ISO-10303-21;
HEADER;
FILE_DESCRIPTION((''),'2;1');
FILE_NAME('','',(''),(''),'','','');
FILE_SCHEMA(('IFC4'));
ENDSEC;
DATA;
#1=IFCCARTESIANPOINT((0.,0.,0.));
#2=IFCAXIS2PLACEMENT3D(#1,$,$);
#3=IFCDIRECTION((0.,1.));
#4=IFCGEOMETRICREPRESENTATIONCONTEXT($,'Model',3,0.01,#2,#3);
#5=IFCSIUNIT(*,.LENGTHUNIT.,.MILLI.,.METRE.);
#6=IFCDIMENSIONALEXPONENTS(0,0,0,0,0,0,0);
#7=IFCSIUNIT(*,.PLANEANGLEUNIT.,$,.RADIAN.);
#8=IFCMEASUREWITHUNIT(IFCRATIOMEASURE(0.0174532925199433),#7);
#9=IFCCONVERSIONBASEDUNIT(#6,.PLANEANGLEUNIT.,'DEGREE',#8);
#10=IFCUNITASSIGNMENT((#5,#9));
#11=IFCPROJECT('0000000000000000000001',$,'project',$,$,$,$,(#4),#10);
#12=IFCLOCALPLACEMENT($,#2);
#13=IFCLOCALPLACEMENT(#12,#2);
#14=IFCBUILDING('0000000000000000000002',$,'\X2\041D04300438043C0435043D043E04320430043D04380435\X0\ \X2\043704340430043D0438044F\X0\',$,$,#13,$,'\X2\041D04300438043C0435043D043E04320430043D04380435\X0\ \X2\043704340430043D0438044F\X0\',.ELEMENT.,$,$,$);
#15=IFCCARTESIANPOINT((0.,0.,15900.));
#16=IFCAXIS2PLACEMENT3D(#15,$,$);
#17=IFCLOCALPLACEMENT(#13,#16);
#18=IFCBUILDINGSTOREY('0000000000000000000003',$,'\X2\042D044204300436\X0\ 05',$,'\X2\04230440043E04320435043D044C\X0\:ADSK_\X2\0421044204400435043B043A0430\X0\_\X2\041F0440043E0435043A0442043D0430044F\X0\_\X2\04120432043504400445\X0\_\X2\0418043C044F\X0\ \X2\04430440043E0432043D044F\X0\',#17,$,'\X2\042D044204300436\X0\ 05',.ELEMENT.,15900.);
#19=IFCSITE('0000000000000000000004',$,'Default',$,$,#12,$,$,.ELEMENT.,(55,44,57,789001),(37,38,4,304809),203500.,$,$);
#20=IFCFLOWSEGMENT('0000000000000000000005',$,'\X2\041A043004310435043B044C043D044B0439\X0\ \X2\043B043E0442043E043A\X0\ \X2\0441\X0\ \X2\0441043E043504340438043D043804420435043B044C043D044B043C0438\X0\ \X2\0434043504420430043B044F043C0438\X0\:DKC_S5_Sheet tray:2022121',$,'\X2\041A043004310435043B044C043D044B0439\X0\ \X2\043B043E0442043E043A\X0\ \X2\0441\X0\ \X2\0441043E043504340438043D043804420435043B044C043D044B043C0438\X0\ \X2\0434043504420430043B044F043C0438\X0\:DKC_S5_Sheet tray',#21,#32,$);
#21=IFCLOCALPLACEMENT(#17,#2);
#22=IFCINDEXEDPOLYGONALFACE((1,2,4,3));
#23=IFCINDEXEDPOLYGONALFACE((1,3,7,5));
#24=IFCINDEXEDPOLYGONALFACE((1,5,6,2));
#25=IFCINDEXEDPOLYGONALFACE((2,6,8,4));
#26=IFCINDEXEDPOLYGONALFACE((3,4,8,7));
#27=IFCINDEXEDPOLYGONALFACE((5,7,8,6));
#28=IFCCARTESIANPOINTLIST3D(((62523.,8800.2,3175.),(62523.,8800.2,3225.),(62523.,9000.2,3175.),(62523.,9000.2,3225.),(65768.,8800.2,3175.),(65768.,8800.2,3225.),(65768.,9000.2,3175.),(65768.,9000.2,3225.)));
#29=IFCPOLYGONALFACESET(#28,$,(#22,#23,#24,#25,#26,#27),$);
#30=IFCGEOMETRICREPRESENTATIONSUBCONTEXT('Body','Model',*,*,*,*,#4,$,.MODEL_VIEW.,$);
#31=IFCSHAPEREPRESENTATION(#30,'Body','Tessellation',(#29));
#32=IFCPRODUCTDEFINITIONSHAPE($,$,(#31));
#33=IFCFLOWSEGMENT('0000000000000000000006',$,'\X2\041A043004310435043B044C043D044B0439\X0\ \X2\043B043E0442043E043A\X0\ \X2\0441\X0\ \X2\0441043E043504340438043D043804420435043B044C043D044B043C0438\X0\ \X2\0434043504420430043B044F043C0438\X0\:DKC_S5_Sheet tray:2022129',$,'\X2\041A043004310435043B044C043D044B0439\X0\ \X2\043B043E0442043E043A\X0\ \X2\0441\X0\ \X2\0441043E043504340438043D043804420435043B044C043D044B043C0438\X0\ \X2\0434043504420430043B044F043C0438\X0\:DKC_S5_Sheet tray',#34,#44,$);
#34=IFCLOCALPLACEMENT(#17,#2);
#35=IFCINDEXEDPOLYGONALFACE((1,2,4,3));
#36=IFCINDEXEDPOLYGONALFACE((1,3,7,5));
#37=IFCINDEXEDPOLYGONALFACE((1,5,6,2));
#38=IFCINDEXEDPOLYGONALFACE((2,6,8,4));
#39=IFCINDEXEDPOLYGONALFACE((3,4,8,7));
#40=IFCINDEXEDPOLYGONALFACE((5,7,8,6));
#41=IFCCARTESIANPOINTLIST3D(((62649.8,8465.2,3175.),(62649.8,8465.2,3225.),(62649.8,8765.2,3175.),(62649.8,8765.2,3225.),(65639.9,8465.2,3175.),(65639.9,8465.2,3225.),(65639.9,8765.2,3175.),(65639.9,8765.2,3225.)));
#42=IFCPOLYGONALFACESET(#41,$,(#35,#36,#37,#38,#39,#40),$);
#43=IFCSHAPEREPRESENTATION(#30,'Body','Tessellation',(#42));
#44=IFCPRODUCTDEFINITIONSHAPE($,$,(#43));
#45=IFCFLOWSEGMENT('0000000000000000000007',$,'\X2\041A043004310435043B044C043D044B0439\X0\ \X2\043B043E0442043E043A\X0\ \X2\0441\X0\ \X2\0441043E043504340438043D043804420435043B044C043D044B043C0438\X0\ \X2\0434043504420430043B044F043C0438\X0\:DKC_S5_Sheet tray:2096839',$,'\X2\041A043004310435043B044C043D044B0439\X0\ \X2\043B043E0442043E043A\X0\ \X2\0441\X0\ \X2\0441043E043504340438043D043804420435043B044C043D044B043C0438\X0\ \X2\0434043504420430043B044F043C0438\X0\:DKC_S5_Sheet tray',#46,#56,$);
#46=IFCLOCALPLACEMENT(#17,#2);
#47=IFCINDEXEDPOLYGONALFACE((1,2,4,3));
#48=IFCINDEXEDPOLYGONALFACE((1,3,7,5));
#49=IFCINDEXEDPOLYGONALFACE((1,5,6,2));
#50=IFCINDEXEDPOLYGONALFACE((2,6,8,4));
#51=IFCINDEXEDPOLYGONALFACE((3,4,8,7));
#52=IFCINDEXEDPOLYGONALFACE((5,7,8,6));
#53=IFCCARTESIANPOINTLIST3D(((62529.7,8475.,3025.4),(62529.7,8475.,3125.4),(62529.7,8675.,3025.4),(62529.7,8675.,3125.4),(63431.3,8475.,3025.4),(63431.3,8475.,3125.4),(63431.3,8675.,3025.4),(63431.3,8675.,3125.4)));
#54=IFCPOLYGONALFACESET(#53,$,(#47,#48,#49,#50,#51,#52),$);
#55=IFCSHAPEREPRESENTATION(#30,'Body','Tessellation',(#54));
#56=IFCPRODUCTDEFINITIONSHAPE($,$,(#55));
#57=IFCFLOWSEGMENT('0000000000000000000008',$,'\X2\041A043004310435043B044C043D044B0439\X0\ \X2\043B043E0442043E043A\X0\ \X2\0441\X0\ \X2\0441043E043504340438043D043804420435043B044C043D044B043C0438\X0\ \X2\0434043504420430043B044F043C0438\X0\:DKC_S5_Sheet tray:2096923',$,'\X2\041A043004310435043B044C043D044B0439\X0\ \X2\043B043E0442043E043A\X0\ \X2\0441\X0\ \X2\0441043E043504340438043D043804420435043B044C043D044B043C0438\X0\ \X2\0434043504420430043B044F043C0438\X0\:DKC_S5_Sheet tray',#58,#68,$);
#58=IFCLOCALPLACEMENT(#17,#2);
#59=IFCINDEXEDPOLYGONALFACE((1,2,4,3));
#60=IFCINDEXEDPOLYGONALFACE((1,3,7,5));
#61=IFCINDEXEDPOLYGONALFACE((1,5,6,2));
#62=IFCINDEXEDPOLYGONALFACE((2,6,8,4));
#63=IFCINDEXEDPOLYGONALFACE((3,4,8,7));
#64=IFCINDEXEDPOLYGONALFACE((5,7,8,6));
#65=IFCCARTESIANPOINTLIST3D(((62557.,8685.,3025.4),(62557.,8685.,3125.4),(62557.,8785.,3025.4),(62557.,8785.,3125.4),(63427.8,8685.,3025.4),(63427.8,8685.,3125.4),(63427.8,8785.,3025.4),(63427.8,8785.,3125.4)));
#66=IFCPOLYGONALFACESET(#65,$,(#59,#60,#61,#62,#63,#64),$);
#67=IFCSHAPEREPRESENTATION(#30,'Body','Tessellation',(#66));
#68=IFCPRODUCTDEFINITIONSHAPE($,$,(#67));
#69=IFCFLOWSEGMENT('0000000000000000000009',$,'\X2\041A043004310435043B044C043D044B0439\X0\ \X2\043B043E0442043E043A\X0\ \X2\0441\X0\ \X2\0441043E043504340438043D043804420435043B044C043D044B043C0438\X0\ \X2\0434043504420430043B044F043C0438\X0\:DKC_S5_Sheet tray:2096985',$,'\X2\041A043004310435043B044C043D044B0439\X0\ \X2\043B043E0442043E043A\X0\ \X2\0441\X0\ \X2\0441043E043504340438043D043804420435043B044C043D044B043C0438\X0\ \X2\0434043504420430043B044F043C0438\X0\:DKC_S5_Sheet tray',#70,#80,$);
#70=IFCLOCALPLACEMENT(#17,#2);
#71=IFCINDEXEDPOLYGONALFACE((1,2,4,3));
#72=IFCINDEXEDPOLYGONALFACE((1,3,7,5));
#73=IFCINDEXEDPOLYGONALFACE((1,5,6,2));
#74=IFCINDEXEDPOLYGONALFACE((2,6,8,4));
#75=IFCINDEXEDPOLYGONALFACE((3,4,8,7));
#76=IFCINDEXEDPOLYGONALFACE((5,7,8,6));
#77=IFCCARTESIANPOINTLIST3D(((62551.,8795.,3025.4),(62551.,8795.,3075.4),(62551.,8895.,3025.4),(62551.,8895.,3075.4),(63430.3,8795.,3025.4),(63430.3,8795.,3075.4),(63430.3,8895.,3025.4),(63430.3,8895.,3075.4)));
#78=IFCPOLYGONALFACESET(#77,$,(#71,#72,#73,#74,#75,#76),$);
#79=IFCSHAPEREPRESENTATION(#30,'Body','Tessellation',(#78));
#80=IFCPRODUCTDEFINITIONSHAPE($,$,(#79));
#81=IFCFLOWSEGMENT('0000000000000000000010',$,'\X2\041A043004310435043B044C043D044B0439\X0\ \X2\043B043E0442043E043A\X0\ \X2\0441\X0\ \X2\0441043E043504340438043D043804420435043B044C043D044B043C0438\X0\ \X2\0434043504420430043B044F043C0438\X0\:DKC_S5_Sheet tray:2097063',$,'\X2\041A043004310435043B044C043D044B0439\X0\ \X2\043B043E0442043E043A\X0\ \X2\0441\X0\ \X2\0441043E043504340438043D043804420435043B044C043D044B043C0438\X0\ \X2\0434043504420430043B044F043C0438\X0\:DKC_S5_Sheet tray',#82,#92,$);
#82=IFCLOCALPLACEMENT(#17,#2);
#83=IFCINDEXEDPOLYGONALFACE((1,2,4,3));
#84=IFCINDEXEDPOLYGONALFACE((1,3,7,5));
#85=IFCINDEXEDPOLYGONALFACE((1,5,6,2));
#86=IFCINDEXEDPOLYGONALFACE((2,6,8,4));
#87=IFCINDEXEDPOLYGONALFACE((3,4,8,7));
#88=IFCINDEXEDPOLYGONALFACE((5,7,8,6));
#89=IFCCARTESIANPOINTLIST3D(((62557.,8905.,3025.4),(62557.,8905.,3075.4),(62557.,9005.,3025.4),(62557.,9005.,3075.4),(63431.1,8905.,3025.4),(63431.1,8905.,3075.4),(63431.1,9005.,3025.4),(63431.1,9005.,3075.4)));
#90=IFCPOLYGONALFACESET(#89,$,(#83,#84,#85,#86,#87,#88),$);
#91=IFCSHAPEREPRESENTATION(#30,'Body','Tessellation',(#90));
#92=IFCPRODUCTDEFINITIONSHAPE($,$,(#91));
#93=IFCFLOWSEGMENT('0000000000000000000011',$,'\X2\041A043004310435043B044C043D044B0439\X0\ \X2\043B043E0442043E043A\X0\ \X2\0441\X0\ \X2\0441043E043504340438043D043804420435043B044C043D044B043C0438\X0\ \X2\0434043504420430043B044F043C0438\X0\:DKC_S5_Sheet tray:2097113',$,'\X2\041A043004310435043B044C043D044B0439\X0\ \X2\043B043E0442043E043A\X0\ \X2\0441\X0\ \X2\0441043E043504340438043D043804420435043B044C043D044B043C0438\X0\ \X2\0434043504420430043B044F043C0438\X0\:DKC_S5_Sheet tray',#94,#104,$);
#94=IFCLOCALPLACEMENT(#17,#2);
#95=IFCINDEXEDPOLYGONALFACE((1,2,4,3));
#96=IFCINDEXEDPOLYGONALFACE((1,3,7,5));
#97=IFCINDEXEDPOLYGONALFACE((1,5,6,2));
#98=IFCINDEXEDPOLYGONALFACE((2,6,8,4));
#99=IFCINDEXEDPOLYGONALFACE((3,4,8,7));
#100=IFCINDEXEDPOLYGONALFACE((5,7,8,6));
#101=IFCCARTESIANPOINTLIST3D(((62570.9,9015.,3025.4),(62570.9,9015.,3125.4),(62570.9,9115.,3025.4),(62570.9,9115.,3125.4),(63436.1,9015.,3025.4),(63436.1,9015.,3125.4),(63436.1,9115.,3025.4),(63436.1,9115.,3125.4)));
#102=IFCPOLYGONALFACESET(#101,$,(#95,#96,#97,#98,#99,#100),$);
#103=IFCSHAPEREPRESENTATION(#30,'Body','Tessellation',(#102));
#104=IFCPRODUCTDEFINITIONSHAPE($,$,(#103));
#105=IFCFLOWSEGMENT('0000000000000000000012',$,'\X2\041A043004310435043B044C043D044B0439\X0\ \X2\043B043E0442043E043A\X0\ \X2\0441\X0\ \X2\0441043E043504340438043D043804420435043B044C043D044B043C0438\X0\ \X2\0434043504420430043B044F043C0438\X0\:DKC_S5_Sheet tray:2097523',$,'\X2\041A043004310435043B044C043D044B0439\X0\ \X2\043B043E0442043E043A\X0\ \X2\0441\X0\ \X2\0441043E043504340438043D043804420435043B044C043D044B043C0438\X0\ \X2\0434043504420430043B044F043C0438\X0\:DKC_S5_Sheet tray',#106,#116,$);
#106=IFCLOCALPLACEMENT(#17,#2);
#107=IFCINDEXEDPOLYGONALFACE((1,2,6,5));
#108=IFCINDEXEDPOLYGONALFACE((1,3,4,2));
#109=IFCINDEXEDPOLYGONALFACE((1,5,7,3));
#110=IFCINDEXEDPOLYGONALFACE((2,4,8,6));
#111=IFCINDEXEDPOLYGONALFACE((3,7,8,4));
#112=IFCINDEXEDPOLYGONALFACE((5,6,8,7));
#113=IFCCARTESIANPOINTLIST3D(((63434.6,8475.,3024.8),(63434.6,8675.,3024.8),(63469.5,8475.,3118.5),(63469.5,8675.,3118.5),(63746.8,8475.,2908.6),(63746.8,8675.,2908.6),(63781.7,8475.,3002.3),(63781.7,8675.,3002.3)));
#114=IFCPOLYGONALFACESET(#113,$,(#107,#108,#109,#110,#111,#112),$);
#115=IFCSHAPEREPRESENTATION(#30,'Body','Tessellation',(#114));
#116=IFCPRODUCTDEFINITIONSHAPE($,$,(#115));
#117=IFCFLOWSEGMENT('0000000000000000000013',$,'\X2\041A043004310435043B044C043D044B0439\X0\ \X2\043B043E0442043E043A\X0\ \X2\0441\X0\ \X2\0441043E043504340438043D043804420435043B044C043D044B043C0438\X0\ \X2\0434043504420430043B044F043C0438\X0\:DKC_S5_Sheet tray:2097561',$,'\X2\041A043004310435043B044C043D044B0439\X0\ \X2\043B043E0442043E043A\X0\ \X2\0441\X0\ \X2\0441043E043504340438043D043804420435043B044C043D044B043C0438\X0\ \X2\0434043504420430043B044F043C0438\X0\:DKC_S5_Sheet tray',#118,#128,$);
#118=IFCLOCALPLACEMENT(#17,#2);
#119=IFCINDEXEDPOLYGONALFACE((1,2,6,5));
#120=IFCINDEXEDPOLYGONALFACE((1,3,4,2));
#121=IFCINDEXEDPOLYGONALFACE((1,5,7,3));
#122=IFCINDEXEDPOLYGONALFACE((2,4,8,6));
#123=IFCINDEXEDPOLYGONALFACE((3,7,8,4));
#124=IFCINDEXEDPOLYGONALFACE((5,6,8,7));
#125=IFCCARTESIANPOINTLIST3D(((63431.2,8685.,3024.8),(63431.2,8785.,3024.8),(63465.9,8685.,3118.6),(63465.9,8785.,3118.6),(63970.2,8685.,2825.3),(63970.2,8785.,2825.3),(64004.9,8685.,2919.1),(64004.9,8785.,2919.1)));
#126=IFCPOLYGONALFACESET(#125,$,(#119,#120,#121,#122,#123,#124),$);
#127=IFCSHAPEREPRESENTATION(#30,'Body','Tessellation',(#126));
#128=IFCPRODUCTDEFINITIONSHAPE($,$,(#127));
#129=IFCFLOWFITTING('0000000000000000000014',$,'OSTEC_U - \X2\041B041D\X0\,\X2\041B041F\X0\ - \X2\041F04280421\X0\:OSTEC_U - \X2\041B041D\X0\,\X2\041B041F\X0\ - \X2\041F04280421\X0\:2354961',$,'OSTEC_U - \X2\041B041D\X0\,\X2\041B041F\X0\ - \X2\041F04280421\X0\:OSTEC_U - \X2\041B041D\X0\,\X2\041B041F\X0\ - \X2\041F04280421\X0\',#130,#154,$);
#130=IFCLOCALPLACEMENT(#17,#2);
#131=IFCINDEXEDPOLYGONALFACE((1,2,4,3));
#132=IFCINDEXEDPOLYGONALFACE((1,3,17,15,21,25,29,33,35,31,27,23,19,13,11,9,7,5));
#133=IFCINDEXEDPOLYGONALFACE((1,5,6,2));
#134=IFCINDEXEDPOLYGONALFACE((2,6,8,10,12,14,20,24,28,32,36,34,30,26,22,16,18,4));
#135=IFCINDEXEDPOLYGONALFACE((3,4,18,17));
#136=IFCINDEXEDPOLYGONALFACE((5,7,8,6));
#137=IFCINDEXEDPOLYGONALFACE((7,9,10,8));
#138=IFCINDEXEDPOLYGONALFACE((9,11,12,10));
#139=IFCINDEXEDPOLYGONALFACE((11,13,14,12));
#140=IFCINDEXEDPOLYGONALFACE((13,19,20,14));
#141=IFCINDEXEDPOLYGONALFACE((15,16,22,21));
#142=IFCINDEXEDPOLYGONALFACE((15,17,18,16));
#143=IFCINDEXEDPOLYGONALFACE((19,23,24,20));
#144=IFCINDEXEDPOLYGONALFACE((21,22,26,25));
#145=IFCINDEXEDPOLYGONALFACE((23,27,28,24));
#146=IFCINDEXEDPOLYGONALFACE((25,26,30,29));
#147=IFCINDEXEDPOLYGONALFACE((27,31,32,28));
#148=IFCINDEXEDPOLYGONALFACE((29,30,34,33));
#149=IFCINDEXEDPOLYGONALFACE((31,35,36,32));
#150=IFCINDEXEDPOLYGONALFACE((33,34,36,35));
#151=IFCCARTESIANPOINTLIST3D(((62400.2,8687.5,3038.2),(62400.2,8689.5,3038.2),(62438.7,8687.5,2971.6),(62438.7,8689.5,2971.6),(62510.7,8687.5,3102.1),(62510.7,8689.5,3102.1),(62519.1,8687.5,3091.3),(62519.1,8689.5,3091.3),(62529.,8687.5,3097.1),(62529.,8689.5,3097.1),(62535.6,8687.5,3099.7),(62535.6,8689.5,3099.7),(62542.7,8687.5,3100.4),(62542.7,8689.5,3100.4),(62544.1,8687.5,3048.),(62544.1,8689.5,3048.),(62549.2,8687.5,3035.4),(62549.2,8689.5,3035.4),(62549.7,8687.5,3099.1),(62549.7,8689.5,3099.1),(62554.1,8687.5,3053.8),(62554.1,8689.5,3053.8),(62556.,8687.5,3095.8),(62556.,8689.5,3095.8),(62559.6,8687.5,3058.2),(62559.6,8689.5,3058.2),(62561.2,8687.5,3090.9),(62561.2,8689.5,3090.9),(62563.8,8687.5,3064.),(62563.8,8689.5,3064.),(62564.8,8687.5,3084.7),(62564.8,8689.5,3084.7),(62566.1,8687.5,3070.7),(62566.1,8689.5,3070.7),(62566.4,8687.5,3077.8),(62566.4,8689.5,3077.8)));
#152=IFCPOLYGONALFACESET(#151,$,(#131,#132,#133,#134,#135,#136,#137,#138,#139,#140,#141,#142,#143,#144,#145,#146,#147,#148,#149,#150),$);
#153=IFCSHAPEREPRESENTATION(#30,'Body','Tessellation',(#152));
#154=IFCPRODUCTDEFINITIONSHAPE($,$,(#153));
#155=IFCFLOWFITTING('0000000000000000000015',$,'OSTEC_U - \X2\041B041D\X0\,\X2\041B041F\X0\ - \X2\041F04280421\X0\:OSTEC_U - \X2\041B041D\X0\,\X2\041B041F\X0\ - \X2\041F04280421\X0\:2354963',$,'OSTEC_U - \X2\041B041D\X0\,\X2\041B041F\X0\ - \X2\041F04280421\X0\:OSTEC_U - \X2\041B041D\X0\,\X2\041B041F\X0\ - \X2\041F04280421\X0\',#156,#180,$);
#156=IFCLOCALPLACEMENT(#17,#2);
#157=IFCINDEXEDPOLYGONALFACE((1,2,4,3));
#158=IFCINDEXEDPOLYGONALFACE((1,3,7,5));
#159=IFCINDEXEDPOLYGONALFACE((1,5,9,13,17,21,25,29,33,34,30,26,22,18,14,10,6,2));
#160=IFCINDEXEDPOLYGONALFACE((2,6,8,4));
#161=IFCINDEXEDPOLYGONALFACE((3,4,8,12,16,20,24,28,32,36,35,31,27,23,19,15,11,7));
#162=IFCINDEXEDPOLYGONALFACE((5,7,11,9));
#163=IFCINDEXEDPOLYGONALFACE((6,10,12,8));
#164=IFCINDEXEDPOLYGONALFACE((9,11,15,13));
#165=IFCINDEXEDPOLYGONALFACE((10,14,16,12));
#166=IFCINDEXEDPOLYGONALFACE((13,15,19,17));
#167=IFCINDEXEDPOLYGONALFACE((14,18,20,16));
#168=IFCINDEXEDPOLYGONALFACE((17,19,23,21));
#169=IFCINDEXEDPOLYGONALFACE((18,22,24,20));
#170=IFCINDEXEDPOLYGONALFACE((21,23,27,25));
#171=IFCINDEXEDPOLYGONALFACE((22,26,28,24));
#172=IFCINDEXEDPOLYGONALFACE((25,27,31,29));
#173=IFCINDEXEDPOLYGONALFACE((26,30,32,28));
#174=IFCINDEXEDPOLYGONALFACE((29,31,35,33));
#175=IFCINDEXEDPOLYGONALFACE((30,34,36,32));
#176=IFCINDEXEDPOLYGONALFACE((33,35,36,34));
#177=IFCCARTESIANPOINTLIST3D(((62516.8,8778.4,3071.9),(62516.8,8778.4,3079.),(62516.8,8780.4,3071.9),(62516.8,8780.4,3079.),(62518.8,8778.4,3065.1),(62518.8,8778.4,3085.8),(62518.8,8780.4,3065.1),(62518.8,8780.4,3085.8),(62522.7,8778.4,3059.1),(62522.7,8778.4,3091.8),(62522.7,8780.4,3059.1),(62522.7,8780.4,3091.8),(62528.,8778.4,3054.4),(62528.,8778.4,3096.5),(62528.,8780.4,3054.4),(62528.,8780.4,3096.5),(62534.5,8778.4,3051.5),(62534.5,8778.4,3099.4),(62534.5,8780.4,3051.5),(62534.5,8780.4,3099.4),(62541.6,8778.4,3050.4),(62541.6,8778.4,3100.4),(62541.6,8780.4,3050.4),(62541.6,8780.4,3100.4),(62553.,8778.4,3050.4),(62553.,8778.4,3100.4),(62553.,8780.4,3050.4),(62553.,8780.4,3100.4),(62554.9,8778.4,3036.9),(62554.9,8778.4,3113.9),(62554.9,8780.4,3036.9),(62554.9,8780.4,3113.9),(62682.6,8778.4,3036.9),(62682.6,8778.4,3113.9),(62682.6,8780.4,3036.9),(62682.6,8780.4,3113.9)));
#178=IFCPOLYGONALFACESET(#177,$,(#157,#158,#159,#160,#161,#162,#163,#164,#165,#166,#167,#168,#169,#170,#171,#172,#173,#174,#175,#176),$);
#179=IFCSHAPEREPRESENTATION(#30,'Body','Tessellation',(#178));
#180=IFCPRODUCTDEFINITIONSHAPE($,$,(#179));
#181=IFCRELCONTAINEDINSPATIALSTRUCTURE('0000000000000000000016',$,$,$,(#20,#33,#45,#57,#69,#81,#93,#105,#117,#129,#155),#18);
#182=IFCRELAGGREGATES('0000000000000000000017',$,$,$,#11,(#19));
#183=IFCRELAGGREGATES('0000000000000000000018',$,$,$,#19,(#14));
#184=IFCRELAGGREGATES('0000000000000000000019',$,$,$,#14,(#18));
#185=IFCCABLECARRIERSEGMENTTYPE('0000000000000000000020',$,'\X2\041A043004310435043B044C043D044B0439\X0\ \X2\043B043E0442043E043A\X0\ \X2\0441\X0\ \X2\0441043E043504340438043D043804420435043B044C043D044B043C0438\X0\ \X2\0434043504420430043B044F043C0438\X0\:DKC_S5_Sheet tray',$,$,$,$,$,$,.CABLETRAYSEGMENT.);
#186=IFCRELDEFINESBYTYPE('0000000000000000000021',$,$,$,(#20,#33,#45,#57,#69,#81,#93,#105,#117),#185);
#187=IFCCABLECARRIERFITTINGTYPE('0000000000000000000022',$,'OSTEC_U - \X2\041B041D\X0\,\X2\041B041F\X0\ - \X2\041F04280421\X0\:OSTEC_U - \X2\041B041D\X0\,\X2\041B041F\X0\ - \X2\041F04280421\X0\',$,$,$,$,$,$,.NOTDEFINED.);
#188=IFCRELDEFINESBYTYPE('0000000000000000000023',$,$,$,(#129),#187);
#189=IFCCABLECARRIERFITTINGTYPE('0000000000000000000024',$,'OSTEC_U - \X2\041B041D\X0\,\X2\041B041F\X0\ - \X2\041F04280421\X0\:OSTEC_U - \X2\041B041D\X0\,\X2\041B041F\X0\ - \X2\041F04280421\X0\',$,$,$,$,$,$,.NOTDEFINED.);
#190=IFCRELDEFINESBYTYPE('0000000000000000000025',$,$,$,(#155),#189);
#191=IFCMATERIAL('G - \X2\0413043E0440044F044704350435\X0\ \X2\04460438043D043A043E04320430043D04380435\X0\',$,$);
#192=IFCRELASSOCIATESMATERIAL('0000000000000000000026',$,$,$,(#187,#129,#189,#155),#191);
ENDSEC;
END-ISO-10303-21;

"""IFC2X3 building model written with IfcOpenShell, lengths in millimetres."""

from ifc_helpers import new_model, entity, si_unit, converted_unit, direction, frame, frame_2d, origin, origin_2d_with_axis, place, context, subcontext, project, spatial, polyline, circle_curve, parameter, trimmed, segment, composite_curve, rectangle, outline, extrude, source, transform, mapped, material, type_object, type_shapes, element, save


model = new_model("IFC2X3")

# Units and contexts
model_context = context("Model", 3, precision=0.01, world=origin(), true_north=direction((0.0, 1.0)))
body_context = subcontext(model_context, "Body", "Model", "MODEL_VIEW")
ifc_project = project(units=[si_unit("LENGTHUNIT", "METRE", prefix="MILLI"), converted_unit("PLANEANGLEUNIT", "DEGREE", entity("IfcRatioMeasure", 0.0174532925199433), si_unit("PLANEANGLEUNIT", "RADIAN"), dimensions=[0, 0, 0, 0, 0, 0, 0])], contexts=[model_context])

# Site, building, storey
site_placement = place(None, origin())
site = spatial("IfcSite", under=ifc_project, at=site_placement, Name="Default", CompositionType="ELEMENT", RefLatitude=(55, 44, 57, 789001), RefLongitude=(37, 38, 4, 304809), RefElevation=203500.0)
building_placement = place(site_placement, origin())
building = spatial("IfcBuilding", under=site, at=building_placement, Name="Наименование здания", LongName="Наименование здания", CompositionType="ELEMENT")
storey_placement = place(building_placement, frame((0.0, 0.0, 15900.0)))
storey = spatial("IfcBuildingStorey", under=building, at=storey_placement, Name="Этаж 05", ObjectType="Уровень:ADSK_Стрелка_Проектная_Вверх_Имя уровня", LongName="Этаж 05", CompositionType="ELEMENT", Elevation=15900.0)

# Flow segments
cable_carrier_segment_type = type_object("IfcCableCarrierSegmentType", Name="Кабельный лоток с соединительными деталями:DKC_S5_Sheet tray", PredefinedType="CABLETRAYSEGMENT")
flow_segment_1_placement = place(storey_placement, frame((62523.0, 8800.1, 3175.0)))
element("IfcFlowSegment", 1, at=flow_segment_1_placement, inside=storey, type_object=cable_carrier_segment_type, Name="Кабельный лоток с соединительными деталями:DKC_S5_Sheet tray:2022121", ObjectType="Кабельный лоток с соединительными деталями:DKC_S5_Sheet tray", context=body_context, shape_type="SweptSolid", body=[
    extrude(rectangle(XDim=3245.0, YDim=200.0, at=origin_2d_with_axis()), frame((1622.5, 100.0, 0.0)), (0.0, 0.0, 1.0), 50.0),
])
flow_segment_2_placement = place(storey_placement, frame((62649.8, 8465.1, 3175.0)))
element("IfcFlowSegment", 2, at=flow_segment_2_placement, inside=storey, type_object=cable_carrier_segment_type, Name="Кабельный лоток с соединительными деталями:DKC_S5_Sheet tray:2022129", ObjectType="Кабельный лоток с соединительными деталями:DKC_S5_Sheet tray", context=body_context, shape_type="SweptSolid", body=[
    extrude(rectangle(XDim=2990.0, YDim=300.0, at=origin_2d_with_axis()), frame((1495.0, 150.0, 0.0)), (0.0, 0.0, 1.0), 50.0),
])
flow_segment_3_placement = place(storey_placement, frame((62529.8, 8475.0, 3025.4)))
element("IfcFlowSegment", 3, at=flow_segment_3_placement, inside=storey, type_object=cable_carrier_segment_type, Name="Кабельный лоток с соединительными деталями:DKC_S5_Sheet tray:2096839", ObjectType="Кабельный лоток с соединительными деталями:DKC_S5_Sheet tray", context=body_context, shape_type="SweptSolid", body=[
    extrude(rectangle(XDim=901.5, YDim=200.0, at=origin_2d_with_axis()), frame((450.8, 100.0, 0.0)), (0.0, 0.0, 1.0), 100.0),
])
flow_segment_4_placement = place(storey_placement, frame((62557.0, 8685.0, 3025.4)))
element("IfcFlowSegment", 4, at=flow_segment_4_placement, inside=storey, type_object=cable_carrier_segment_type, Name="Кабельный лоток с соединительными деталями:DKC_S5_Sheet tray:2096923", ObjectType="Кабельный лоток с соединительными деталями:DKC_S5_Sheet tray", context=body_context, shape_type="SweptSolid", body=[
    extrude(rectangle(XDim=870.8, YDim=100.0, at=origin_2d_with_axis()), frame((435.4, 50.0, 0.0)), (0.0, 0.0, 1.0), 100.0),
])
flow_segment_5_placement = place(storey_placement, frame((62551.0, 8795.0, 3025.4)))
element("IfcFlowSegment", 5, at=flow_segment_5_placement, inside=storey, type_object=cable_carrier_segment_type, Name="Кабельный лоток с соединительными деталями:DKC_S5_Sheet tray:2096985", ObjectType="Кабельный лоток с соединительными деталями:DKC_S5_Sheet tray", context=body_context, shape_type="SweptSolid", body=[
    extrude(rectangle(XDim=879.3, YDim=100.0, at=origin_2d_with_axis()), frame((439.6, 50.0, 0.0)), (0.0, 0.0, 1.0), 50.0),
])
flow_segment_6_placement = place(storey_placement, frame((62557.0, 8905.0, 3025.4)))
element("IfcFlowSegment", 6, at=flow_segment_6_placement, inside=storey, type_object=cable_carrier_segment_type, Name="Кабельный лоток с соединительными деталями:DKC_S5_Sheet tray:2097063", ObjectType="Кабельный лоток с соединительными деталями:DKC_S5_Sheet tray", context=body_context, shape_type="SweptSolid", body=[
    extrude(rectangle(XDim=874.2, YDim=100.0, at=origin_2d_with_axis()), frame((437.1, 50.0, 0.0)), (0.0, 0.0, 1.0), 50.0),
])
flow_segment_7_placement = place(storey_placement, frame((62570.9, 9015.0, 3025.4)))
element("IfcFlowSegment", 7, at=flow_segment_7_placement, inside=storey, type_object=cable_carrier_segment_type, Name="Кабельный лоток с соединительными деталями:DKC_S5_Sheet tray:2097113", ObjectType="Кабельный лоток с соединительными деталями:DKC_S5_Sheet tray", context=body_context, shape_type="SweptSolid", body=[
    extrude(rectangle(XDim=865.2, YDim=100.0, at=origin_2d_with_axis()), frame((432.6, 50.0, 0.0)), (0.0, 0.0, 1.0), 100.0),
])
flow_segment_8_placement = place(storey_placement, frame((63434.6, 8475.0, 2908.6)))
element("IfcFlowSegment", 8, at=flow_segment_8_placement, inside=storey, type_object=cable_carrier_segment_type, Name="Кабельный лоток с соединительными деталями:DKC_S5_Sheet tray:2097523", ObjectType="Кабельный лоток с соединительными деталями:DKC_S5_Sheet tray", context=body_context, shape_type="SweptSolid", body=[
    extrude(rectangle(XDim=100.0, YDim=200.0, at=origin_2d_with_axis()), frame((17.4, 100.0, 163.1), z_axis=(0.937108, 0.0, -0.349039), x_axis=(0.349039, 0.0, 0.937108)), (0.0, 0.0, 1.0), 333.1),
])
flow_segment_9_placement = place(storey_placement, frame((63431.2, 8685.0, 2825.3)))
element("IfcFlowSegment", 9, at=flow_segment_9_placement, inside=storey, type_object=cable_carrier_segment_type, Name="Кабельный лоток с соединительными деталями:DKC_S5_Sheet tray:2097561", ObjectType="Кабельный лоток с соединительными деталями:DKC_S5_Sheet tray", context=body_context, shape_type="SweptSolid", body=[
    extrude(rectangle(XDim=100.0, YDim=100.0, at=origin_2d_with_axis()), frame((17.4, 50.0, 246.4), z_axis=(0.937802, 0.0, -0.347171), x_axis=(0.347171, 0.0, 0.937802)), (0.0, 0.0, 1.0), 574.8),
])

# Flow fittings
ifc_material_1 = material(Name="G - Горячее цинкование")
cable_carrier_fitting_type_1 = type_object("IfcCableCarrierFittingType", Name="OSTEC_U - ЛН,ЛП - ПШС:OSTEC_U - ЛН,ЛП - ПШС", PredefinedType="NOTDEFINED", material=ifc_material_1)
shared_shape_1 = source(origin(), body_context, "Body", "SweptSolid", [
    extrude(outline(composite_curve([segment(trimmed(circle_curve(frame_2d((-41.5, 0.0), x_axis=(1.0, 0.0)), 25.0), [parameter(90.0)], [parameter(270.0)], True, "PARAMETER"), True, "CONTINUOUS"), segment(polyline([(-41.5, -25.0), (-30.0, -25.0)]), True, "CONTINUOUS"), segment(polyline([(-30.0, -25.0), (-28.1, -38.5)]), True, "CONTINUOUS"), segment(polyline([(-28.1, -38.5), (99.5, -38.5)]), True, "CONTINUOUS"), segment(polyline([(99.5, -38.5), (99.5, 38.5)]), True, "CONTINUOUS"), segment(polyline([(99.5, 38.5), (-28.1, 38.5)]), True, "CONTINUOUS"), segment(polyline([(-28.1, 38.5), (-30.0, 25.0)]), True, "CONTINUOUS"), segment(polyline([(-30.0, 25.0), (-41.5, 25.0)]), True, "CONTINUOUS")], self_intersect=False)), frame((41.5, 0.0, 0.0), z_axis=(0.0, 0.0, -1.0), x_axis=(1.0, 0.0, 0.0)), (0.0, 0.0, -1.0), 2.0),
])
type_shapes(cable_carrier_fitting_type_1, [shared_shape_1])
flow_fitting_1_placement = place(storey_placement, frame((62541.6, 8689.5, 3075.4), z_axis=(0.0, -1.0, 0.0), x_axis=(-0.865893, 0.0, -0.500229)))
element("IfcFlowFitting", 10, at=flow_fitting_1_placement, inside=storey, type_object=cable_carrier_fitting_type_1, material=ifc_material_1, Name="OSTEC_U - ЛН,ЛП - ПШС:OSTEC_U - ЛН,ЛП - ПШС:2354961", ObjectType="OSTEC_U - ЛН,ЛП - ПШС:OSTEC_U - ЛН,ЛП - ПШС", context=body_context, shape_type="MappedRepresentation", body=[
    mapped(shared_shape_1, transform((0.0, 0.0, 0.0), scale=1.0)),
])
cable_carrier_fitting_type_2 = type_object("IfcCableCarrierFittingType", Name="OSTEC_U - ЛН,ЛП - ПШС:OSTEC_U - ЛН,ЛП - ПШС", PredefinedType="NOTDEFINED", material=ifc_material_1)
type_shapes(cable_carrier_fitting_type_2, [shared_shape_1])
flow_fitting_2_placement = place(storey_placement, frame((62541.6, 8778.4, 3075.4), z_axis=(0.0, 1.0, 0.0), x_axis=(1.0, 0.0, 0.0)))
element("IfcFlowFitting", 11, at=flow_fitting_2_placement, inside=storey, type_object=cable_carrier_fitting_type_2, material=ifc_material_1, Name="OSTEC_U - ЛН,ЛП - ПШС:OSTEC_U - ЛН,ЛП - ПШС:2354963", ObjectType="OSTEC_U - ЛН,ЛП - ПШС:OSTEC_U - ЛН,ЛП - ПШС", context=body_context, shape_type="MappedRepresentation", body=[
    mapped(shared_shape_1, transform((0.0, 0.0, 0.0), scale=1.0)),
])

save(model, "model.ifc")
